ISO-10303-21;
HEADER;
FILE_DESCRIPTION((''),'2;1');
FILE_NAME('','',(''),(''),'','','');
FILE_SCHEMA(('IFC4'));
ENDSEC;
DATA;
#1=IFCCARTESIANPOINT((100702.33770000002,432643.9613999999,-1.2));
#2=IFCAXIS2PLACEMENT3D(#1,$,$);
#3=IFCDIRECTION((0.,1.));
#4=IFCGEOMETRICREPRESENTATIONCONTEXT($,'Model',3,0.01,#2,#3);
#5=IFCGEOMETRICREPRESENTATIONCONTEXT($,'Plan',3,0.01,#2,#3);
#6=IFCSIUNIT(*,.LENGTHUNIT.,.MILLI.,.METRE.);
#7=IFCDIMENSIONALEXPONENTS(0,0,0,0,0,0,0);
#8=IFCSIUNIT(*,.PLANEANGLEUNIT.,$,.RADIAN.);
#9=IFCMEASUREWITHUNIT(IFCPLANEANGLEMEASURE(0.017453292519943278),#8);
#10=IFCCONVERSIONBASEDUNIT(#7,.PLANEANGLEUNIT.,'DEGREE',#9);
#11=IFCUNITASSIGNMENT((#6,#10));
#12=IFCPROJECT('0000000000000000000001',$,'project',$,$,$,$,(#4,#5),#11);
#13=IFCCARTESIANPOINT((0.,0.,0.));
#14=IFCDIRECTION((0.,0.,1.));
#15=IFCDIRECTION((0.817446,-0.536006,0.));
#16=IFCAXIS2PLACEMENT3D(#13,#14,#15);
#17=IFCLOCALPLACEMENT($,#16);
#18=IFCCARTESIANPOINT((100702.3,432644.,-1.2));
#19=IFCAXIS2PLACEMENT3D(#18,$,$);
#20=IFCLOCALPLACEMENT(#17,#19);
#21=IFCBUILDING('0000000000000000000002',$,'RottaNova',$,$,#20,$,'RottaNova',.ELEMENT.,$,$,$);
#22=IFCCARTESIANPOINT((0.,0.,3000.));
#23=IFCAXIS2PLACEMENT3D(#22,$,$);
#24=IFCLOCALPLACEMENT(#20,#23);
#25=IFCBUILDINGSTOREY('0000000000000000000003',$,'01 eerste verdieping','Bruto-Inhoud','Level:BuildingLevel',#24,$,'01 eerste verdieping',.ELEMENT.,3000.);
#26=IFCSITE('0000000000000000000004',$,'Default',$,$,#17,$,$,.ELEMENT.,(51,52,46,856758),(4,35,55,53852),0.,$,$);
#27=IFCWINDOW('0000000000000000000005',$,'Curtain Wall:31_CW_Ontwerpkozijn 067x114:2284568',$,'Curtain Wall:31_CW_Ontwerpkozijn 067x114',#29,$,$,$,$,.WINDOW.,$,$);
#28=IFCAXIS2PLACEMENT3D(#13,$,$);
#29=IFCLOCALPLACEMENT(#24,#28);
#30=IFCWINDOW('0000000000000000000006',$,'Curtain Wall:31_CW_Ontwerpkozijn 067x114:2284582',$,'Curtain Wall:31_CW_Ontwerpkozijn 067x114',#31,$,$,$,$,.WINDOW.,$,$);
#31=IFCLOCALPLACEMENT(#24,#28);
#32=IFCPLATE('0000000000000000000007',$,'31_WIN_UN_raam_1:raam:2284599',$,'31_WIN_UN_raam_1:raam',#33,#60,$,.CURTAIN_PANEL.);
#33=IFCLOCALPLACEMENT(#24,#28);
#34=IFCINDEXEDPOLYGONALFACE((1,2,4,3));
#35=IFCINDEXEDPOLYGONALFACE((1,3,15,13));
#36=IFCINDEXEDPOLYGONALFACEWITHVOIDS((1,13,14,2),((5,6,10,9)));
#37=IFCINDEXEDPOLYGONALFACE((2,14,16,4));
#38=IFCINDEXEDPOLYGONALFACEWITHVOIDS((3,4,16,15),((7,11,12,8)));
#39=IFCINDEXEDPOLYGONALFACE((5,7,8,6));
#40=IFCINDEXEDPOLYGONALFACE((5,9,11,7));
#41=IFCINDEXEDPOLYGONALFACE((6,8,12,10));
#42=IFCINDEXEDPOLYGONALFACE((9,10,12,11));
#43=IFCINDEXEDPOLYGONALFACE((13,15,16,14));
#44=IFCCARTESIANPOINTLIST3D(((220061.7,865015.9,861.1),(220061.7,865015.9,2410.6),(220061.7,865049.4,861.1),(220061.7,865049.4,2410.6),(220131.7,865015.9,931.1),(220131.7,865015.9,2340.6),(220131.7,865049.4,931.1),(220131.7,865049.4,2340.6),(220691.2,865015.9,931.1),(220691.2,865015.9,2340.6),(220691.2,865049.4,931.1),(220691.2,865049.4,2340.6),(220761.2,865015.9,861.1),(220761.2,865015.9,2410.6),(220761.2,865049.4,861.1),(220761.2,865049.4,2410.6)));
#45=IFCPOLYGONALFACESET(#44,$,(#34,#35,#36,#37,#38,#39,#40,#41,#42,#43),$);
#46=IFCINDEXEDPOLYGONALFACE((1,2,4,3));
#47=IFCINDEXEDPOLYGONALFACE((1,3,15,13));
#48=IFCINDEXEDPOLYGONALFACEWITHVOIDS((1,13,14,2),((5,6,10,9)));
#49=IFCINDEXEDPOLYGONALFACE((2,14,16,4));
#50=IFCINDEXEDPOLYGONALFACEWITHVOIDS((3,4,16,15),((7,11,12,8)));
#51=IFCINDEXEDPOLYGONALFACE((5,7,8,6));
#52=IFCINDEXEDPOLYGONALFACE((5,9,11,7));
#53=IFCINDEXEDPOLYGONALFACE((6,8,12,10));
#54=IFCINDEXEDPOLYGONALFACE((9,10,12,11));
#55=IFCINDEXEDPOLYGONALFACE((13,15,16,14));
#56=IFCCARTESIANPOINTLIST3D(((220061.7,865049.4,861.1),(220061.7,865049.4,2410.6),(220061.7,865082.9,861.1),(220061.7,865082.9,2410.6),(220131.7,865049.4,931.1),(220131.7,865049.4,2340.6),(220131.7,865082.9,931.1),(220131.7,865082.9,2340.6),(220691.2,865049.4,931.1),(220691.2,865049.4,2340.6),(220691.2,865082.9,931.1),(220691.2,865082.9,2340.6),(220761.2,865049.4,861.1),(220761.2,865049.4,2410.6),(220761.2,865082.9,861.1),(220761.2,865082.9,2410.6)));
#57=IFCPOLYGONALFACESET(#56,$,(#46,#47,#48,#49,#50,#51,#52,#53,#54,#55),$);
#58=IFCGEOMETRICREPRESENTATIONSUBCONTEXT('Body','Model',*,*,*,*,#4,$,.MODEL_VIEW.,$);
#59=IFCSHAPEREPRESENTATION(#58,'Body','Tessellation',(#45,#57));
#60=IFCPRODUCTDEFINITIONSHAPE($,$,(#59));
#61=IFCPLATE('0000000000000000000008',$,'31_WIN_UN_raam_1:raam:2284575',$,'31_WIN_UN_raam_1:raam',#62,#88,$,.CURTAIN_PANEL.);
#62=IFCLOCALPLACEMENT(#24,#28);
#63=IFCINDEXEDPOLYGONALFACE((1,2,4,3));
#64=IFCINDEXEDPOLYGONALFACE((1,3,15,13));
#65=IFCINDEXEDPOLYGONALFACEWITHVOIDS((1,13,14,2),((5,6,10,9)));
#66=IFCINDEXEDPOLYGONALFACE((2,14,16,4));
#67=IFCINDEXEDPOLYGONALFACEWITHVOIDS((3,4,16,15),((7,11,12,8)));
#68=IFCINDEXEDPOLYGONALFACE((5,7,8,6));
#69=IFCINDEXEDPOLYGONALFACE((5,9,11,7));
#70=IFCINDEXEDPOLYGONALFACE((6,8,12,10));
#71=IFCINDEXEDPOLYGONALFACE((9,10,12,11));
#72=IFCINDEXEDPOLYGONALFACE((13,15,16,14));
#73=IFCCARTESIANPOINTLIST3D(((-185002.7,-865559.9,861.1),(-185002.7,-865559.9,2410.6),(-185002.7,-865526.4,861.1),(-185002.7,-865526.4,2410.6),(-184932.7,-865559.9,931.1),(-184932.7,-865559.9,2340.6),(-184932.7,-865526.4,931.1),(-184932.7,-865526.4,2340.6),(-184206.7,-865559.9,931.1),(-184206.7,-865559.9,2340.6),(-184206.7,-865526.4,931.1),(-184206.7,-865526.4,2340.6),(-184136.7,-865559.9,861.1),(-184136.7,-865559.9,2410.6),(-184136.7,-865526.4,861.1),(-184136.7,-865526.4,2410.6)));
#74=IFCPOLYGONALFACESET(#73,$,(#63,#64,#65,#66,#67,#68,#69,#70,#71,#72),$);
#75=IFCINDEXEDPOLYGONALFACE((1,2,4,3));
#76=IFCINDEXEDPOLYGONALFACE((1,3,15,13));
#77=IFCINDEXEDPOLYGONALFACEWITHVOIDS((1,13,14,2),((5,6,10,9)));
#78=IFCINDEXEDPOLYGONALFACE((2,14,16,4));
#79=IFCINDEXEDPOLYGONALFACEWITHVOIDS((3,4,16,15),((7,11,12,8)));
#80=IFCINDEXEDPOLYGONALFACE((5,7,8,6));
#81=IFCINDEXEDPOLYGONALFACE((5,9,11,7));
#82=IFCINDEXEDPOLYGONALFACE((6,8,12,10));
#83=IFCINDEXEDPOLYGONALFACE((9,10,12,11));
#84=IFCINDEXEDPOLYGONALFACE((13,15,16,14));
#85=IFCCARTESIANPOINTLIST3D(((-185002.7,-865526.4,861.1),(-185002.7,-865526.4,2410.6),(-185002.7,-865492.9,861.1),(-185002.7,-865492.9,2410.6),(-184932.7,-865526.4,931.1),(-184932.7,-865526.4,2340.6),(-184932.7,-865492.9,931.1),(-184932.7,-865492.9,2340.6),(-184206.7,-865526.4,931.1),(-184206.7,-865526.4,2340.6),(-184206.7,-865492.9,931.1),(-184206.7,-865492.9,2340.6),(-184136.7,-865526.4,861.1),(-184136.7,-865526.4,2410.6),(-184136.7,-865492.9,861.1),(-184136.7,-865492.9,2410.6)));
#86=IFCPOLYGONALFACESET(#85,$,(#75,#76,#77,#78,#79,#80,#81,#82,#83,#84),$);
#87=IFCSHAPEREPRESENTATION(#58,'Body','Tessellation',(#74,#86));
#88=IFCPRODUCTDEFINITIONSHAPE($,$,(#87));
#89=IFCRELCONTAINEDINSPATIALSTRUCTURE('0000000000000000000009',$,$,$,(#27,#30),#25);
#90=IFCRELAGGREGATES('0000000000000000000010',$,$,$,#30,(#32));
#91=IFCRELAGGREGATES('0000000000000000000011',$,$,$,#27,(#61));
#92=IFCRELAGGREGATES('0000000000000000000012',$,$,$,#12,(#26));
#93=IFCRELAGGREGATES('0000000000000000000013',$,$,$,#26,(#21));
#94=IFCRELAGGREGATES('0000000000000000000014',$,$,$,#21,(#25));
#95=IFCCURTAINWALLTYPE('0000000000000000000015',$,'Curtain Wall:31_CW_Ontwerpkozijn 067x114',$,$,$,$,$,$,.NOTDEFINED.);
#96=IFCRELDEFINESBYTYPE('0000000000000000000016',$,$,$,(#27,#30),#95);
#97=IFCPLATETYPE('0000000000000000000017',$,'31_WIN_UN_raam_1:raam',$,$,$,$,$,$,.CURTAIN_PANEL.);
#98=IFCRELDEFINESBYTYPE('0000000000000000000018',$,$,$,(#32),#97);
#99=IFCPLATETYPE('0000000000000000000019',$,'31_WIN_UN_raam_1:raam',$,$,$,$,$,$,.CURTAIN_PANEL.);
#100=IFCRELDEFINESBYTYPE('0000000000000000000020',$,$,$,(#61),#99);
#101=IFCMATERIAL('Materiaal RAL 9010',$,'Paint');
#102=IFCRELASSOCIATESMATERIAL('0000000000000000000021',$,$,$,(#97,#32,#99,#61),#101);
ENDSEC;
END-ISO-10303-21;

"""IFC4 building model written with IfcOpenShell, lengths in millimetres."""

from ifc_helpers import new_model, entity, si_unit, converted_unit, direction, frame, place, context, subcontext, project, spatial, indexed_curve, outline, extrude, source, transform, mapped, material, type_object, type_shapes, element, aggregate, save


model = new_model("IFC4")

# Units and contexts
model_context = context("Model", 3, precision=0.01, world=frame((100702.33770000002, 432643.9613999999, -1.2)), true_north=direction((0.0, 1.0)))
plan_context = context("Plan", 3, precision=0.01, world=frame((100702.33770000002, 432643.9613999999, -1.2)), true_north=direction((0.0, 1.0)))
body_context = subcontext(model_context, "Body", "Model", "MODEL_VIEW")
ifc_project = project(units=[si_unit("LENGTHUNIT", "METRE", prefix="MILLI"), converted_unit("PLANEANGLEUNIT", "DEGREE", entity("IfcPlaneAngleMeasure", 0.017453292519943278), si_unit("PLANEANGLEUNIT", "RADIAN"), dimensions=[0, 0, 0, 0, 0, 0, 0])], contexts=[model_context, plan_context])

# Site, building, storey
site_placement = place(None, frame((0.0, 0.0, 0.0), z_axis=(0.0, 0.0, 1.0), x_axis=(0.817446, -0.536006, 0.0)))
site = spatial("IfcSite", under=ifc_project, at=site_placement, Name="Default", CompositionType="ELEMENT", RefLatitude=(51, 52, 46, 856758), RefLongitude=(4, 35, 55, 53852), RefElevation=0.0)
building_placement = place(site_placement, frame((100702.3, 432644.0, -1.2)))
building = spatial("IfcBuilding", under=site, at=building_placement, Name="RottaNova", LongName="RottaNova", CompositionType="ELEMENT")
storey_placement = place(building_placement, frame((0.0, 0.0, 3000.0)))
storey = spatial("IfcBuildingStorey", under=building, at=storey_placement, Name="01 eerste verdieping", Description="Bruto-Inhoud", ObjectType="Level:BuildingLevel", LongName="01 eerste verdieping", CompositionType="ELEMENT", Elevation=3000.0)

# Window
curtain_wall_type = type_object("IfcCurtainWallType", Name="Curtain Wall:31_CW_Ontwerpkozijn 067x114", PredefinedType="NOTDEFINED")
window_1_placement = place(storey_placement, frame((0.0, 0.0, -3000.0)))
window_1 = element("IfcWindow", 1, at=window_1_placement, inside=storey, type_object=curtain_wall_type, Name="Curtain Wall:31_CW_Ontwerpkozijn 067x114:2284568", ObjectType="Curtain Wall:31_CW_Ontwerpkozijn 067x114", PredefinedType="WINDOW")

# Window
window_2_placement = place(storey_placement, frame((0.0, 0.0, -3000.0)))
window_2 = element("IfcWindow", 2, at=window_2_placement, inside=storey, type_object=curtain_wall_type, Name="Curtain Wall:31_CW_Ontwerpkozijn 067x114:2284582", ObjectType="Curtain Wall:31_CW_Ontwerpkozijn 067x114", PredefinedType="WINDOW")

# Plates
ifc_material_1 = material(Name="Materiaal RAL 9010", Category="Paint")
plate_type_1 = type_object("IfcPlateType", Name="31_WIN_UN_raam_1:raam", PredefinedType="CURTAIN_PANEL", material=ifc_material_1)
shared_shape_1 = source(frame((100702.3, 432644.0, -1.2)), body_context, "Body", "SweptSolid", [
    extrude(outline(indexed_curve([(-349.7, -774.8), (349.7, -774.8), (349.7, 774.8), (-349.7, 774.8), (-349.7, -774.8)], self_intersect=False), holes=[indexed_curve([(-279.7, 704.8), (279.7, 704.8), (279.7, -704.8), (-279.7, -704.8), (-279.7, 704.8)], self_intersect=False)]), frame((0.0, -92.0, 774.8), z_axis=(0.0, 1.0, 0.0), x_axis=(1.0, 0.0, 0.0)), (0.0, 0.0, 1.0), 33.5),
    extrude(outline(indexed_curve([(-349.7, -774.8), (349.7, -774.8), (349.7, 774.8), (-349.7, 774.8), (-349.7, -774.8)], self_intersect=False), holes=[indexed_curve([(-279.7, 704.7), (279.7, 704.7), (279.7, -704.8), (-279.7, -704.8), (-279.7, 704.7)], self_intersect=False)]), frame((0.0, -58.5, 774.8), z_axis=(0.0, 1.0, 0.0), x_axis=(1.0, 0.0, 0.0)), (0.0, 0.0, 1.0), 33.5),
])
type_shapes(plate_type_1, [shared_shape_1])
plate_1_placement = place(window_2_placement, frame((19006.8, -180.0, 3863.5)))
plate_1 = element("IfcPlate", 3, at=plate_1_placement, type_object=plate_type_1, material=ifc_material_1, Name="31_WIN_UN_raam_1:raam:2284599", ObjectType="31_WIN_UN_raam_1:raam", PredefinedType="CURTAIN_PANEL", context=body_context, shape_type="MappedRepresentation", body=[
    mapped(shared_shape_1, transform((100702.3, 432644.0, -1.2), scale=1.0)),
])
aggregate(window_2, [plate_1])
plate_type_2 = type_object("IfcPlateType", Name="31_WIN_UN_raam_1:raam", PredefinedType="CURTAIN_PANEL", material=ifc_material_1)
shared_shape_2 = source(frame((100702.3, 432644.0, -1.2)), body_context, "Body", "SweptSolid", [
    extrude(outline(indexed_curve([(-433.0, -774.7), (433.0, -774.7), (433.0, 774.7), (-433.0, 774.7), (-433.0, -774.7)], self_intersect=False), holes=[indexed_curve([(-363.0, 704.7), (363.0, 704.7), (363.0, -704.8), (-363.0, -704.8), (-363.0, 704.7)], self_intersect=False)]), frame((0.0, 58.5, 774.8), z_axis=(0.0, 1.0, 0.0), x_axis=(1.0, 0.0, 0.0)), (0.0, 0.0, 1.0), 33.5),
    extrude(outline(indexed_curve([(-433.0, -774.7), (433.0, -774.7), (433.0, 774.7), (-433.0, 774.7), (-433.0, -774.7)], self_intersect=False), holes=[indexed_curve([(-363.0, 704.7), (363.0, 704.7), (363.0, -704.8), (-363.0, -704.8), (-363.0, 704.7)], self_intersect=False)]), frame((0.0, 25.0, 774.8), z_axis=(0.0, 1.0, 0.0), x_axis=(1.0, 0.0, 0.0)), (0.0, 0.0, 1.0), 33.5),
])
type_shapes(plate_type_2, [shared_shape_2])
plate_2_placement = place(window_1_placement, frame((16835.0, -180.0, 3863.5), z_axis=(0.0, 0.0, 1.0), x_axis=(-1.0, 0.0, 0.0)))
plate_2 = element("IfcPlate", 4, at=plate_2_placement, type_object=plate_type_2, material=ifc_material_1, Name="31_WIN_UN_raam_1:raam:2284575", ObjectType="31_WIN_UN_raam_1:raam", PredefinedType="CURTAIN_PANEL", context=body_context, shape_type="MappedRepresentation", body=[
    mapped(shared_shape_2, transform((100702.3, 432644.0, -1.2), scale=1.0)),
])
aggregate(window_1, [plate_2])

save(model, "model.ifc")
